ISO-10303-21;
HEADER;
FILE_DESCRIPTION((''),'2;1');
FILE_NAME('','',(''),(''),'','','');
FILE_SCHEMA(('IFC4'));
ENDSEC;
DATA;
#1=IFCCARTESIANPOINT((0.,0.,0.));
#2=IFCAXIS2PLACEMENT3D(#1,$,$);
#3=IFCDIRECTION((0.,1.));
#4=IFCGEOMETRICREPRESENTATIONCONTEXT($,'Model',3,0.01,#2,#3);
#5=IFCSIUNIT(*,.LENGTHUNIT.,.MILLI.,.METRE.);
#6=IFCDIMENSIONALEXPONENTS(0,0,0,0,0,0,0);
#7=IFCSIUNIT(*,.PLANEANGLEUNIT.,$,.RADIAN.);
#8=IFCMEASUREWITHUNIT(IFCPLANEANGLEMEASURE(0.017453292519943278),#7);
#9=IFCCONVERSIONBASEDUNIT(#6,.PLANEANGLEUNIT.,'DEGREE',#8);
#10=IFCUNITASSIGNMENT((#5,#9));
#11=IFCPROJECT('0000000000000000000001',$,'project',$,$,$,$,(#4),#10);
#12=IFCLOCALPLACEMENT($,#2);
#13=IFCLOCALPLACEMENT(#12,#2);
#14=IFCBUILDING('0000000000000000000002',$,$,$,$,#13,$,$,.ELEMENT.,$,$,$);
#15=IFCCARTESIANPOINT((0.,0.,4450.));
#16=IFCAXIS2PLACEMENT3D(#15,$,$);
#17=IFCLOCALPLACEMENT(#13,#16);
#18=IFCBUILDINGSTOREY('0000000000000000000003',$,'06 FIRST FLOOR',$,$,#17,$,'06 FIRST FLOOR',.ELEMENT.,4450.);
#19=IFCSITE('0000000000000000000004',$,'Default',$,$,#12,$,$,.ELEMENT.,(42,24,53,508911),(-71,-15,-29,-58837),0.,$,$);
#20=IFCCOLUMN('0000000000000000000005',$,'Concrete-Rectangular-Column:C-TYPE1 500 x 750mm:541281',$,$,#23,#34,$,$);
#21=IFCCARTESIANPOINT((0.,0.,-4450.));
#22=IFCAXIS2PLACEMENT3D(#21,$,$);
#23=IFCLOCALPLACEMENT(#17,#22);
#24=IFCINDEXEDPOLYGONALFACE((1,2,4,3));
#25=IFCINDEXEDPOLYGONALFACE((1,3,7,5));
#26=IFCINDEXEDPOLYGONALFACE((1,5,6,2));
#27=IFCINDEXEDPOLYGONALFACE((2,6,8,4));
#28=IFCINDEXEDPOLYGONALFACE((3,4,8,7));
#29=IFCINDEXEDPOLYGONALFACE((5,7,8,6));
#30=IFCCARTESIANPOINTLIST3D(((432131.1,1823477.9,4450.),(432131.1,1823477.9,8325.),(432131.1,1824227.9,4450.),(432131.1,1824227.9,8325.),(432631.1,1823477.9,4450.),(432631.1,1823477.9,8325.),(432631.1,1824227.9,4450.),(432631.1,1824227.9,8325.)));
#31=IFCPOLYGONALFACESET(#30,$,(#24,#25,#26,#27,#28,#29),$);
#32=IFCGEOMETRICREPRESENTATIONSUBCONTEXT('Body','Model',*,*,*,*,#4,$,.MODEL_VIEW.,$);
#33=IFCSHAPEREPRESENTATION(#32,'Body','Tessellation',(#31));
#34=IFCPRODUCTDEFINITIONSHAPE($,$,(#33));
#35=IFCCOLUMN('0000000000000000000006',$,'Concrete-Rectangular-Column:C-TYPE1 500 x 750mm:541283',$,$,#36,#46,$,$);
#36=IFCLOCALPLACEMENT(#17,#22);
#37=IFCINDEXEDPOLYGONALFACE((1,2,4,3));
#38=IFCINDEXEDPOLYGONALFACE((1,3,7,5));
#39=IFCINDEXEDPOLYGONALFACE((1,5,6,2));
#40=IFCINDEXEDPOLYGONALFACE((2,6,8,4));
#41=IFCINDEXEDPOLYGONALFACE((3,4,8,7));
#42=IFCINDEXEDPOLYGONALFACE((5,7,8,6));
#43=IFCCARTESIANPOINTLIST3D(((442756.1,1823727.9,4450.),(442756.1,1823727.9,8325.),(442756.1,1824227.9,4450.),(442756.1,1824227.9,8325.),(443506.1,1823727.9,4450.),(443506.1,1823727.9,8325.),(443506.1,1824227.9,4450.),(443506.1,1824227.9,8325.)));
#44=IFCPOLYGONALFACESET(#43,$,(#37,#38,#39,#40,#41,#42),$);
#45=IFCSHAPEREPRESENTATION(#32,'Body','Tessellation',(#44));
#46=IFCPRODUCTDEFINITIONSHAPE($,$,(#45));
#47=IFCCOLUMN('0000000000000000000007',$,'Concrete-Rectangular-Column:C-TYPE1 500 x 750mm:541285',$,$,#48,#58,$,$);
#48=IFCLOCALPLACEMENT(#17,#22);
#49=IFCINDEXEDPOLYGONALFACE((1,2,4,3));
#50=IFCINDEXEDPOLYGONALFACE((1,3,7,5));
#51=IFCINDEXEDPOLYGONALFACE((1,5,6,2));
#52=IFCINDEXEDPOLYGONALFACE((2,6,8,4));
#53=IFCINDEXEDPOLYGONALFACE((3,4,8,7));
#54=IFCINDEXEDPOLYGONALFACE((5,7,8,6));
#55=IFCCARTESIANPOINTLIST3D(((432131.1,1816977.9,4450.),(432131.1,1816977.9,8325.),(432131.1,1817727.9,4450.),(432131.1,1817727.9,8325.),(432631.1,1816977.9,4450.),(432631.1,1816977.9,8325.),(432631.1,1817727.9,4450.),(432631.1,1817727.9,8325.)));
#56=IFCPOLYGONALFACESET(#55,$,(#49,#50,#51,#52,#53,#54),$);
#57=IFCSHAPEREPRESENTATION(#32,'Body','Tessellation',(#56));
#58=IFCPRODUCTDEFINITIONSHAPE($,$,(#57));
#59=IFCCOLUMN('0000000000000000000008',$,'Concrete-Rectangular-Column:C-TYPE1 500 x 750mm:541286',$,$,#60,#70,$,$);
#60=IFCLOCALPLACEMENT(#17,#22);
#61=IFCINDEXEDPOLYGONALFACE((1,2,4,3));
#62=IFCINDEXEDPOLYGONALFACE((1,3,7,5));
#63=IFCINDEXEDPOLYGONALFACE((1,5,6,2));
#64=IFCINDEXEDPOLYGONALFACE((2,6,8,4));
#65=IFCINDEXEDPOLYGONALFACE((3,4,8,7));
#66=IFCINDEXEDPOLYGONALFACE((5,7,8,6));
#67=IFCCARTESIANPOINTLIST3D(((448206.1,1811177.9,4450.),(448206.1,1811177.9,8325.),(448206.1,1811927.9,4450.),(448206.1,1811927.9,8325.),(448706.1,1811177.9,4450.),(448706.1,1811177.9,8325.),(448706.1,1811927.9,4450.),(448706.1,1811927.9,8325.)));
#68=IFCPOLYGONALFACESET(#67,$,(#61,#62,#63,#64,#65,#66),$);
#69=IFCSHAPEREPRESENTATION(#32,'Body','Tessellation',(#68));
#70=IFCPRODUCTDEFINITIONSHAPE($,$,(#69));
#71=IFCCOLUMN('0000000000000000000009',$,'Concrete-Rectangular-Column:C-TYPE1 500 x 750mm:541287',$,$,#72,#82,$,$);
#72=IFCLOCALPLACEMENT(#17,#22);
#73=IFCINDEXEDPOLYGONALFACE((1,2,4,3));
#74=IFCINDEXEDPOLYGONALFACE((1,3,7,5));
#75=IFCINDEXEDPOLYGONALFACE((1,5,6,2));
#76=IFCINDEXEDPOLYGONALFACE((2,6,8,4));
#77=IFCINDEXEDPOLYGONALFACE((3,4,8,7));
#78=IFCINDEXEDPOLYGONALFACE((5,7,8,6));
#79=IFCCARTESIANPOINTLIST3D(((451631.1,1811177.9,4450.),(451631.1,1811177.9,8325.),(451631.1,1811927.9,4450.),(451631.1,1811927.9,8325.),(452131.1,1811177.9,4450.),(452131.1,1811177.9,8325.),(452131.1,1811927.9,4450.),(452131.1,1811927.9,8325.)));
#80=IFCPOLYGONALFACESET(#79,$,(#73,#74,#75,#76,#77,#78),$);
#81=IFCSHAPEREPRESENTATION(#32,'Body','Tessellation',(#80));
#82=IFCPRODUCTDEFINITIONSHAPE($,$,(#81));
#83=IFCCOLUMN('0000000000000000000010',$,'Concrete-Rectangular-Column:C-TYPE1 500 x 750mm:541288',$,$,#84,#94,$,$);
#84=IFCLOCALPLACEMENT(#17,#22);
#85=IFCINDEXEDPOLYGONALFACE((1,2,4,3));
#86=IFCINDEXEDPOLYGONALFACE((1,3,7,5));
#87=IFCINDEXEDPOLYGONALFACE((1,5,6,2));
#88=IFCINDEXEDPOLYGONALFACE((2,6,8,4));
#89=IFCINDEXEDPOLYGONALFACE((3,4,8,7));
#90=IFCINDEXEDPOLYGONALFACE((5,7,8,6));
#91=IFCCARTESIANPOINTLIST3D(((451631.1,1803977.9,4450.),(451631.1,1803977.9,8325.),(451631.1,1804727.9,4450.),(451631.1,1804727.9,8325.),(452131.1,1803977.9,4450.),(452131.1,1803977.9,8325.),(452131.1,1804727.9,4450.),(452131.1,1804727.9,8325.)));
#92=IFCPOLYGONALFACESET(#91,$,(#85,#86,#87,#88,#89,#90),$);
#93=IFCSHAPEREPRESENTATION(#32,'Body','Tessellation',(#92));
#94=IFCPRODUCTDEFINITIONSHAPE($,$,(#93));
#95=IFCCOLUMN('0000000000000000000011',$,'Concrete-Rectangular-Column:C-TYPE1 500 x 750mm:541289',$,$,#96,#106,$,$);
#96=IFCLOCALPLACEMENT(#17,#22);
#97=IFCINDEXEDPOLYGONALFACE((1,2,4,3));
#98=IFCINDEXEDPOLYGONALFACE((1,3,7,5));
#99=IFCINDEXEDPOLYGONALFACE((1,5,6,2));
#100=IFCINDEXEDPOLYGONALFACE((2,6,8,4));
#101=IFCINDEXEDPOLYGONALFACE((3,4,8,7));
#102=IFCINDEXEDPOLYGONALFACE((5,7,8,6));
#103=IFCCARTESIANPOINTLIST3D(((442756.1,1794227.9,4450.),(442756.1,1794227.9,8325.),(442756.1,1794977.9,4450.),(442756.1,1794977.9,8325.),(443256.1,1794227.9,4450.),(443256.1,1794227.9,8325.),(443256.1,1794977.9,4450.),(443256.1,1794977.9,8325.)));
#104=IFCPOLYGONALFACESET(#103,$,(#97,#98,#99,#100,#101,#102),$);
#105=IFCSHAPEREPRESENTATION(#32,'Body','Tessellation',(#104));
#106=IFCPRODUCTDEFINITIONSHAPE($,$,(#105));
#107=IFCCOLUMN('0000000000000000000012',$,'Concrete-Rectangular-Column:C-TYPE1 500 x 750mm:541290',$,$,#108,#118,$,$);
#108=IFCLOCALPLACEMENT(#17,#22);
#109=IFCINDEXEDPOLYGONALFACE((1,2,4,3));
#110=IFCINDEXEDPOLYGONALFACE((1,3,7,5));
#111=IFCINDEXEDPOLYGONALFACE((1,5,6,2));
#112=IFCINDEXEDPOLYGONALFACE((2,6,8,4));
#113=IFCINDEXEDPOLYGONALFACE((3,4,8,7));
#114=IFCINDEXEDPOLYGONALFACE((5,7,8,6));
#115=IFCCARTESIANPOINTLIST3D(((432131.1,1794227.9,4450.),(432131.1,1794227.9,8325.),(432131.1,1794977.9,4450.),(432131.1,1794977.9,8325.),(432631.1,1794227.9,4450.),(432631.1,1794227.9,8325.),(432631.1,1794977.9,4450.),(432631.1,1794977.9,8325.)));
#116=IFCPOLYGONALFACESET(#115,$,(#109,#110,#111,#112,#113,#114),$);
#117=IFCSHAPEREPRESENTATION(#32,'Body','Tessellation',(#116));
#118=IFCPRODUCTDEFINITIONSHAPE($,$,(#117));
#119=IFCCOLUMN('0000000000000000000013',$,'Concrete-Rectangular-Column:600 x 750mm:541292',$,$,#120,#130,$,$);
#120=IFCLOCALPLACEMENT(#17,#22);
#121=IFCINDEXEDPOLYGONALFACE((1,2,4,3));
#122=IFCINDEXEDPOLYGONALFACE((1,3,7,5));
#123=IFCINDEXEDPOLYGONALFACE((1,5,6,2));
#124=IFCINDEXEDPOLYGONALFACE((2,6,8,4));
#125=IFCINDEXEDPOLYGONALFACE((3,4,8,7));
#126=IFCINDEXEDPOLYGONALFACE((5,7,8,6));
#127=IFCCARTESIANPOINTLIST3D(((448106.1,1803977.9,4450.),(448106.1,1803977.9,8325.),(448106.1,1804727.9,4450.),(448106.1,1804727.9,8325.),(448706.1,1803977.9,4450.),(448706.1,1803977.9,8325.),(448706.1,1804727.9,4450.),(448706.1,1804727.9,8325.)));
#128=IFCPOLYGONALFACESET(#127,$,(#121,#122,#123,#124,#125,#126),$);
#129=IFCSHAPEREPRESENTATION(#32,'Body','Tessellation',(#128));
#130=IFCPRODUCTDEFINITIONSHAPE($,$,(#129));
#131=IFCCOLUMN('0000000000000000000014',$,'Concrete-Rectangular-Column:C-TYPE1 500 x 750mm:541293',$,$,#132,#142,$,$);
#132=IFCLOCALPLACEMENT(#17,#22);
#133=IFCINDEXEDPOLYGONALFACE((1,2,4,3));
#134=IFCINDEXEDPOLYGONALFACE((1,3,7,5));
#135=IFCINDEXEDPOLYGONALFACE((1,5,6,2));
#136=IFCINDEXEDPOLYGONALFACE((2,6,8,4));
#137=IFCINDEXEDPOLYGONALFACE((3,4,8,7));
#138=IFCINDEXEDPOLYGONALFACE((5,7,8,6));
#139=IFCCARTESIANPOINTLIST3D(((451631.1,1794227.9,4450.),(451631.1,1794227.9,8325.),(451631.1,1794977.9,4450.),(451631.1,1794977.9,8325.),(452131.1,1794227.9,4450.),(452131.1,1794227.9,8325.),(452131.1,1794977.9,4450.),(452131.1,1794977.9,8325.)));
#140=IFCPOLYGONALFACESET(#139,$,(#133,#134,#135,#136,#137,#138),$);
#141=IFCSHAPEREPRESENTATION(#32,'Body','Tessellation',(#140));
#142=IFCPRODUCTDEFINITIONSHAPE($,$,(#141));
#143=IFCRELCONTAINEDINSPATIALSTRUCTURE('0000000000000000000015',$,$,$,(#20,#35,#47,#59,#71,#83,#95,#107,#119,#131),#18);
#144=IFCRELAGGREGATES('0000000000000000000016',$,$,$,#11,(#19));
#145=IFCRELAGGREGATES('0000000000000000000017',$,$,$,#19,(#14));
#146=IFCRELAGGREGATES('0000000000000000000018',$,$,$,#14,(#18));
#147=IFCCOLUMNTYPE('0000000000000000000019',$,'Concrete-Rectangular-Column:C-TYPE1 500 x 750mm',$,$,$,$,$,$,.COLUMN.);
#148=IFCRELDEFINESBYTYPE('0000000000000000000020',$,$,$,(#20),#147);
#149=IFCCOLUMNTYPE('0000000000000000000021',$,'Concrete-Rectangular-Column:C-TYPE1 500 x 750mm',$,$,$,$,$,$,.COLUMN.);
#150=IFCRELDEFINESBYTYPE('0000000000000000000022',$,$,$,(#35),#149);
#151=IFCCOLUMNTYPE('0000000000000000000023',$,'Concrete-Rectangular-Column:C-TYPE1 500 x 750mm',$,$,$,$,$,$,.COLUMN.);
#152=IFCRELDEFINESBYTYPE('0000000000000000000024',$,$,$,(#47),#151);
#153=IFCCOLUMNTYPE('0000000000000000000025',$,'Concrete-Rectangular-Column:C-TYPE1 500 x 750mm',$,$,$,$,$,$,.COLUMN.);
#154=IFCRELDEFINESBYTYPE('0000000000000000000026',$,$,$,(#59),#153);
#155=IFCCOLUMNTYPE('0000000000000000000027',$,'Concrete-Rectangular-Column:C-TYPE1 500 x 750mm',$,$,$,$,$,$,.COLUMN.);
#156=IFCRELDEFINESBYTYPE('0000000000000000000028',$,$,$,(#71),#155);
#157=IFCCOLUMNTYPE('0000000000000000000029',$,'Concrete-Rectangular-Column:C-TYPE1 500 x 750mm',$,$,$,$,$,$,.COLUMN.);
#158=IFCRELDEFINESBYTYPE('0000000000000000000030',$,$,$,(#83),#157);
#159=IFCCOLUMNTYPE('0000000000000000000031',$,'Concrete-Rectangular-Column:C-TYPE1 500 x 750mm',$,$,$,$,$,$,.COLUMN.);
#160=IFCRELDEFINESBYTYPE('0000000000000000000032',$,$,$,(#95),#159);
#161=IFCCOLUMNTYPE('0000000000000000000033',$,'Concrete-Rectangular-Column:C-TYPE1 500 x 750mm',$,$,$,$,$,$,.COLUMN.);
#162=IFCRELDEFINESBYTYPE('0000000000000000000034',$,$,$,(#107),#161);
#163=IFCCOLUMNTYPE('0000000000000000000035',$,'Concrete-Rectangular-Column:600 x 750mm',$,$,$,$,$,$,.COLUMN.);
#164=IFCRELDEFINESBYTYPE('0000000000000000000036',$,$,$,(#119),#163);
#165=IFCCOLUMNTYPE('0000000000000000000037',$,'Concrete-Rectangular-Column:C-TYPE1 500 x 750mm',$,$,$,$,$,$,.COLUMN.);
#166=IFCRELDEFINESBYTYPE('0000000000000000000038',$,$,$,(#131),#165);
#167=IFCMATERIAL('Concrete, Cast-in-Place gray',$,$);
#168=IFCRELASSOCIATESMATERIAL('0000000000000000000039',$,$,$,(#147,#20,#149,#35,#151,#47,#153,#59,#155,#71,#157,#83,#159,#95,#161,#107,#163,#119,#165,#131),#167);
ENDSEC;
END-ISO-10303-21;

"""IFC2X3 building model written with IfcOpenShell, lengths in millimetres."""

from ifc_helpers import new_model, entity, si_unit, converted_unit, direction, frame, frame_2d, origin, place, context, subcontext, project, spatial, rectangle, extrude, source, transform, mapped, material, type_object, type_shapes, element, save


model = new_model("IFC2X3")

# Units and contexts
model_context = context("Model", 3, precision=0.01, world=origin(), true_north=direction((0.0, 1.0)))
body_context = subcontext(model_context, "Body", "Model", "MODEL_VIEW")
ifc_project = project(units=[si_unit("LENGTHUNIT", "METRE", prefix="MILLI"), converted_unit("PLANEANGLEUNIT", "DEGREE", entity("IfcPlaneAngleMeasure", 0.017453292519943278), si_unit("PLANEANGLEUNIT", "RADIAN"), dimensions=[0, 0, 0, 0, 0, 0, 0])], contexts=[model_context])

# Site, building, storey
site_placement = place(None, origin())
site = spatial("IfcSite", under=ifc_project, at=site_placement, Name="Default", CompositionType="ELEMENT", RefLatitude=(42, 24, 53, 508911), RefLongitude=(-71, -15, -29, -58837), RefElevation=0.0)
building_placement = place(site_placement, origin())
building = spatial("IfcBuilding", under=site, at=building_placement, CompositionType="ELEMENT")
storey_placement = place(building_placement, frame((0.0, 0.0, 4450.0)))
storey = spatial("IfcBuildingStorey", under=building, at=storey_placement, Name="06 FIRST FLOOR", LongName="06 FIRST FLOOR", CompositionType="ELEMENT", Elevation=4450.0)

# Columns
ifc_material_1 = material(Name="Concrete, Cast-in-Place gray")
column_type_1 = type_object("IfcColumnType", Name="Concrete-Rectangular-Column:C-TYPE1 500 x 750mm", PredefinedType="COLUMN", material=ifc_material_1)
shared_shape_1 = source(origin(), body_context, "Body", "SweptSolid", [
    extrude(rectangle(XDim=3875.0, YDim=750.0, at=frame_2d((0.0, 0.0), x_axis=(1.0, 0.0))), frame((432131.1, 1823852.9, 6387.5), z_axis=(1.0, 0.0, 0.0), x_axis=(0.0, 0.0, 1.0)), (0.0, 0.0, 1.0), 500.0),
])
type_shapes(column_type_1, [shared_shape_1])
column_1_placement = place(storey_placement, frame((0.0, 0.0, -4450.0)))
element("IfcColumn", 1, at=column_1_placement, inside=storey, type_object=column_type_1, material=ifc_material_1, Name="Concrete-Rectangular-Column:C-TYPE1 500 x 750mm:541281", context=body_context, shape_type="MappedRepresentation", body=[
    mapped(shared_shape_1, transform((0.0, 0.0, 0.0), scale=1.0)),
])
column_type_2 = type_object("IfcColumnType", Name="Concrete-Rectangular-Column:C-TYPE1 500 x 750mm", PredefinedType="COLUMN", material=ifc_material_1)
shared_shape_2 = source(origin(), body_context, "Body", "SweptSolid", [
    extrude(rectangle(XDim=500.0, YDim=750.0, at=frame_2d((0.0, 0.0), x_axis=(1.0, 0.0))), frame((443131.1, 1823977.9, 4450.0), z_axis=(0.0, 0.0, 1.0), x_axis=(0.0, -1.0, 0.0)), (0.0, 0.0, 1.0), 3875.0),
])
type_shapes(column_type_2, [shared_shape_2])
column_2_placement = place(storey_placement, frame((0.0, 0.0, -4450.0)))
element("IfcColumn", 2, at=column_2_placement, inside=storey, type_object=column_type_2, material=ifc_material_1, Name="Concrete-Rectangular-Column:C-TYPE1 500 x 750mm:541283", context=body_context, shape_type="MappedRepresentation", body=[
    mapped(shared_shape_2, transform((0.0, 0.0, 0.0), scale=1.0)),
])
column_type_3 = type_object("IfcColumnType", Name="Concrete-Rectangular-Column:C-TYPE1 500 x 750mm", PredefinedType="COLUMN", material=ifc_material_1)
shared_shape_3 = source(origin(), body_context, "Body", "SweptSolid", [
    extrude(rectangle(XDim=3875.0, YDim=750.0, at=frame_2d((0.0, 0.0), x_axis=(1.0, 0.0))), frame((432131.1, 1817352.9, 6387.5), z_axis=(1.0, 0.0, 0.0), x_axis=(0.0, 0.0, 1.0)), (0.0, 0.0, 1.0), 500.0),
])
type_shapes(column_type_3, [shared_shape_3])
column_3_placement = place(storey_placement, frame((0.0, 0.0, -4450.0)))
element("IfcColumn", 3, at=column_3_placement, inside=storey, type_object=column_type_3, material=ifc_material_1, Name="Concrete-Rectangular-Column:C-TYPE1 500 x 750mm:541285", context=body_context, shape_type="MappedRepresentation", body=[
    mapped(shared_shape_3, transform((0.0, 0.0, 0.0), scale=1.0)),
])
column_type_4 = type_object("IfcColumnType", Name="Concrete-Rectangular-Column:C-TYPE1 500 x 750mm", PredefinedType="COLUMN", material=ifc_material_1)
shared_shape_4 = source(origin(), body_context, "Body", "SweptSolid", [
    extrude(rectangle(XDim=3875.0, YDim=750.0, at=frame_2d((0.0, 0.0), x_axis=(1.0, 0.0))), frame((448206.1, 1811552.9, 6387.5), z_axis=(1.0, 0.0, 0.0), x_axis=(0.0, 0.0, 1.0)), (0.0, 0.0, 1.0), 500.0),
])
type_shapes(column_type_4, [shared_shape_4])
column_4_placement = place(storey_placement, frame((0.0, 0.0, -4450.0)))
element("IfcColumn", 4, at=column_4_placement, inside=storey, type_object=column_type_4, material=ifc_material_1, Name="Concrete-Rectangular-Column:C-TYPE1 500 x 750mm:541286", context=body_context, shape_type="MappedRepresentation", body=[
    mapped(shared_shape_4, transform((0.0, 0.0, 0.0), scale=1.0)),
])
column_type_5 = type_object("IfcColumnType", Name="Concrete-Rectangular-Column:C-TYPE1 500 x 750mm", PredefinedType="COLUMN", material=ifc_material_1)
shared_shape_5 = source(origin(), body_context, "Body", "SweptSolid", [
    extrude(rectangle(XDim=3875.0, YDim=750.0, at=frame_2d((0.0, 0.0), x_axis=(1.0, 0.0))), frame((451631.1, 1811552.9, 6387.5), z_axis=(1.0, 0.0, 0.0), x_axis=(0.0, 0.0, 1.0)), (0.0, 0.0, 1.0), 500.0),
])
type_shapes(column_type_5, [shared_shape_5])
column_5_placement = place(storey_placement, frame((0.0, 0.0, -4450.0)))
element("IfcColumn", 5, at=column_5_placement, inside=storey, type_object=column_type_5, material=ifc_material_1, Name="Concrete-Rectangular-Column:C-TYPE1 500 x 750mm:541287", context=body_context, shape_type="MappedRepresentation", body=[
    mapped(shared_shape_5, transform((0.0, 0.0, 0.0), scale=1.0)),
])
column_type_6 = type_object("IfcColumnType", Name="Concrete-Rectangular-Column:C-TYPE1 500 x 750mm", PredefinedType="COLUMN", material=ifc_material_1)
shared_shape_6 = source(origin(), body_context, "Body", "SweptSolid", [
    extrude(rectangle(XDim=3875.0, YDim=750.0, at=frame_2d((0.0, 0.0), x_axis=(1.0, 0.0))), frame((451631.1, 1804352.9, 6387.5), z_axis=(1.0, 0.0, 0.0), x_axis=(0.0, 0.0, 1.0)), (0.0, 0.0, 1.0), 500.0),
])
type_shapes(column_type_6, [shared_shape_6])
column_6_placement = place(storey_placement, frame((0.0, 0.0, -4450.0)))
element("IfcColumn", 6, at=column_6_placement, inside=storey, type_object=column_type_6, material=ifc_material_1, Name="Concrete-Rectangular-Column:C-TYPE1 500 x 750mm:541288", context=body_context, shape_type="MappedRepresentation", body=[
    mapped(shared_shape_6, transform((0.0, 0.0, 0.0), scale=1.0)),
])
column_type_7 = type_object("IfcColumnType", Name="Concrete-Rectangular-Column:C-TYPE1 500 x 750mm", PredefinedType="COLUMN", material=ifc_material_1)
shared_shape_7 = source(origin(), body_context, "Body", "SweptSolid", [
    extrude(rectangle(XDim=3875.0, YDim=750.0, at=frame_2d((0.0, 0.0), x_axis=(1.0, 0.0))), frame((442756.1, 1794602.9, 6387.5), z_axis=(1.0, 0.0, 0.0), x_axis=(0.0, 0.0, 1.0)), (0.0, 0.0, 1.0), 500.0),
])
type_shapes(column_type_7, [shared_shape_7])
column_7_placement = place(storey_placement, frame((0.0, 0.0, -4450.0)))
element("IfcColumn", 7, at=column_7_placement, inside=storey, type_object=column_type_7, material=ifc_material_1, Name="Concrete-Rectangular-Column:C-TYPE1 500 x 750mm:541289", context=body_context, shape_type="MappedRepresentation", body=[
    mapped(shared_shape_7, transform((0.0, 0.0, 0.0), scale=1.0)),
])
column_type_8 = type_object("IfcColumnType", Name="Concrete-Rectangular-Column:C-TYPE1 500 x 750mm", PredefinedType="COLUMN", material=ifc_material_1)
shared_shape_8 = source(origin(), body_context, "Body", "SweptSolid", [
    extrude(rectangle(XDim=3875.0, YDim=750.0, at=frame_2d((0.0, 0.0), x_axis=(1.0, 0.0))), frame((432131.1, 1794602.9, 6387.5), z_axis=(1.0, 0.0, 0.0), x_axis=(0.0, 0.0, 1.0)), (0.0, 0.0, 1.0), 500.0),
])
type_shapes(column_type_8, [shared_shape_8])
column_8_placement = place(storey_placement, frame((0.0, 0.0, -4450.0)))
element("IfcColumn", 8, at=column_8_placement, inside=storey, type_object=column_type_8, material=ifc_material_1, Name="Concrete-Rectangular-Column:C-TYPE1 500 x 750mm:541290", context=body_context, shape_type="MappedRepresentation", body=[
    mapped(shared_shape_8, transform((0.0, 0.0, 0.0), scale=1.0)),
])
column_type_9 = type_object("IfcColumnType", Name="Concrete-Rectangular-Column:600 x 750mm", PredefinedType="COLUMN", material=ifc_material_1)
shared_shape_9 = source(origin(), body_context, "Body", "SweptSolid", [
    extrude(rectangle(XDim=3875.0, YDim=750.0, at=frame_2d((0.0, 0.0), x_axis=(1.0, 0.0))), frame((448106.1, 1804352.9, 6387.5), z_axis=(1.0, 0.0, 0.0), x_axis=(0.0, 0.0, 1.0)), (0.0, 0.0, 1.0), 600.0),
])
type_shapes(column_type_9, [shared_shape_9])
column_9_placement = place(storey_placement, frame((0.0, 0.0, -4450.0)))
element("IfcColumn", 9, at=column_9_placement, inside=storey, type_object=column_type_9, material=ifc_material_1, Name="Concrete-Rectangular-Column:600 x 750mm:541292", context=body_context, shape_type="MappedRepresentation", body=[
    mapped(shared_shape_9, transform((0.0, 0.0, 0.0), scale=1.0)),
])
column_type_10 = type_object("IfcColumnType", Name="Concrete-Rectangular-Column:C-TYPE1 500 x 750mm", PredefinedType="COLUMN", material=ifc_material_1)
shared_shape_10 = source(origin(), body_context, "Body", "SweptSolid", [
    extrude(rectangle(XDim=3875.0, YDim=750.0, at=frame_2d((0.0, 0.0), x_axis=(1.0, 0.0))), frame((451631.1, 1794602.9, 6387.5), z_axis=(1.0, 0.0, 0.0), x_axis=(0.0, 0.0, 1.0)), (0.0, 0.0, 1.0), 500.0),
])
type_shapes(column_type_10, [shared_shape_10])
column_10_placement = place(storey_placement, frame((0.0, 0.0, -4450.0)))
element("IfcColumn", 10, at=column_10_placement, inside=storey, type_object=column_type_10, material=ifc_material_1, Name="Concrete-Rectangular-Column:C-TYPE1 500 x 750mm:541293", context=body_context, shape_type="MappedRepresentation", body=[
    mapped(shared_shape_10, transform((0.0, 0.0, 0.0), scale=1.0)),
])

save(model, "model.ifc")
